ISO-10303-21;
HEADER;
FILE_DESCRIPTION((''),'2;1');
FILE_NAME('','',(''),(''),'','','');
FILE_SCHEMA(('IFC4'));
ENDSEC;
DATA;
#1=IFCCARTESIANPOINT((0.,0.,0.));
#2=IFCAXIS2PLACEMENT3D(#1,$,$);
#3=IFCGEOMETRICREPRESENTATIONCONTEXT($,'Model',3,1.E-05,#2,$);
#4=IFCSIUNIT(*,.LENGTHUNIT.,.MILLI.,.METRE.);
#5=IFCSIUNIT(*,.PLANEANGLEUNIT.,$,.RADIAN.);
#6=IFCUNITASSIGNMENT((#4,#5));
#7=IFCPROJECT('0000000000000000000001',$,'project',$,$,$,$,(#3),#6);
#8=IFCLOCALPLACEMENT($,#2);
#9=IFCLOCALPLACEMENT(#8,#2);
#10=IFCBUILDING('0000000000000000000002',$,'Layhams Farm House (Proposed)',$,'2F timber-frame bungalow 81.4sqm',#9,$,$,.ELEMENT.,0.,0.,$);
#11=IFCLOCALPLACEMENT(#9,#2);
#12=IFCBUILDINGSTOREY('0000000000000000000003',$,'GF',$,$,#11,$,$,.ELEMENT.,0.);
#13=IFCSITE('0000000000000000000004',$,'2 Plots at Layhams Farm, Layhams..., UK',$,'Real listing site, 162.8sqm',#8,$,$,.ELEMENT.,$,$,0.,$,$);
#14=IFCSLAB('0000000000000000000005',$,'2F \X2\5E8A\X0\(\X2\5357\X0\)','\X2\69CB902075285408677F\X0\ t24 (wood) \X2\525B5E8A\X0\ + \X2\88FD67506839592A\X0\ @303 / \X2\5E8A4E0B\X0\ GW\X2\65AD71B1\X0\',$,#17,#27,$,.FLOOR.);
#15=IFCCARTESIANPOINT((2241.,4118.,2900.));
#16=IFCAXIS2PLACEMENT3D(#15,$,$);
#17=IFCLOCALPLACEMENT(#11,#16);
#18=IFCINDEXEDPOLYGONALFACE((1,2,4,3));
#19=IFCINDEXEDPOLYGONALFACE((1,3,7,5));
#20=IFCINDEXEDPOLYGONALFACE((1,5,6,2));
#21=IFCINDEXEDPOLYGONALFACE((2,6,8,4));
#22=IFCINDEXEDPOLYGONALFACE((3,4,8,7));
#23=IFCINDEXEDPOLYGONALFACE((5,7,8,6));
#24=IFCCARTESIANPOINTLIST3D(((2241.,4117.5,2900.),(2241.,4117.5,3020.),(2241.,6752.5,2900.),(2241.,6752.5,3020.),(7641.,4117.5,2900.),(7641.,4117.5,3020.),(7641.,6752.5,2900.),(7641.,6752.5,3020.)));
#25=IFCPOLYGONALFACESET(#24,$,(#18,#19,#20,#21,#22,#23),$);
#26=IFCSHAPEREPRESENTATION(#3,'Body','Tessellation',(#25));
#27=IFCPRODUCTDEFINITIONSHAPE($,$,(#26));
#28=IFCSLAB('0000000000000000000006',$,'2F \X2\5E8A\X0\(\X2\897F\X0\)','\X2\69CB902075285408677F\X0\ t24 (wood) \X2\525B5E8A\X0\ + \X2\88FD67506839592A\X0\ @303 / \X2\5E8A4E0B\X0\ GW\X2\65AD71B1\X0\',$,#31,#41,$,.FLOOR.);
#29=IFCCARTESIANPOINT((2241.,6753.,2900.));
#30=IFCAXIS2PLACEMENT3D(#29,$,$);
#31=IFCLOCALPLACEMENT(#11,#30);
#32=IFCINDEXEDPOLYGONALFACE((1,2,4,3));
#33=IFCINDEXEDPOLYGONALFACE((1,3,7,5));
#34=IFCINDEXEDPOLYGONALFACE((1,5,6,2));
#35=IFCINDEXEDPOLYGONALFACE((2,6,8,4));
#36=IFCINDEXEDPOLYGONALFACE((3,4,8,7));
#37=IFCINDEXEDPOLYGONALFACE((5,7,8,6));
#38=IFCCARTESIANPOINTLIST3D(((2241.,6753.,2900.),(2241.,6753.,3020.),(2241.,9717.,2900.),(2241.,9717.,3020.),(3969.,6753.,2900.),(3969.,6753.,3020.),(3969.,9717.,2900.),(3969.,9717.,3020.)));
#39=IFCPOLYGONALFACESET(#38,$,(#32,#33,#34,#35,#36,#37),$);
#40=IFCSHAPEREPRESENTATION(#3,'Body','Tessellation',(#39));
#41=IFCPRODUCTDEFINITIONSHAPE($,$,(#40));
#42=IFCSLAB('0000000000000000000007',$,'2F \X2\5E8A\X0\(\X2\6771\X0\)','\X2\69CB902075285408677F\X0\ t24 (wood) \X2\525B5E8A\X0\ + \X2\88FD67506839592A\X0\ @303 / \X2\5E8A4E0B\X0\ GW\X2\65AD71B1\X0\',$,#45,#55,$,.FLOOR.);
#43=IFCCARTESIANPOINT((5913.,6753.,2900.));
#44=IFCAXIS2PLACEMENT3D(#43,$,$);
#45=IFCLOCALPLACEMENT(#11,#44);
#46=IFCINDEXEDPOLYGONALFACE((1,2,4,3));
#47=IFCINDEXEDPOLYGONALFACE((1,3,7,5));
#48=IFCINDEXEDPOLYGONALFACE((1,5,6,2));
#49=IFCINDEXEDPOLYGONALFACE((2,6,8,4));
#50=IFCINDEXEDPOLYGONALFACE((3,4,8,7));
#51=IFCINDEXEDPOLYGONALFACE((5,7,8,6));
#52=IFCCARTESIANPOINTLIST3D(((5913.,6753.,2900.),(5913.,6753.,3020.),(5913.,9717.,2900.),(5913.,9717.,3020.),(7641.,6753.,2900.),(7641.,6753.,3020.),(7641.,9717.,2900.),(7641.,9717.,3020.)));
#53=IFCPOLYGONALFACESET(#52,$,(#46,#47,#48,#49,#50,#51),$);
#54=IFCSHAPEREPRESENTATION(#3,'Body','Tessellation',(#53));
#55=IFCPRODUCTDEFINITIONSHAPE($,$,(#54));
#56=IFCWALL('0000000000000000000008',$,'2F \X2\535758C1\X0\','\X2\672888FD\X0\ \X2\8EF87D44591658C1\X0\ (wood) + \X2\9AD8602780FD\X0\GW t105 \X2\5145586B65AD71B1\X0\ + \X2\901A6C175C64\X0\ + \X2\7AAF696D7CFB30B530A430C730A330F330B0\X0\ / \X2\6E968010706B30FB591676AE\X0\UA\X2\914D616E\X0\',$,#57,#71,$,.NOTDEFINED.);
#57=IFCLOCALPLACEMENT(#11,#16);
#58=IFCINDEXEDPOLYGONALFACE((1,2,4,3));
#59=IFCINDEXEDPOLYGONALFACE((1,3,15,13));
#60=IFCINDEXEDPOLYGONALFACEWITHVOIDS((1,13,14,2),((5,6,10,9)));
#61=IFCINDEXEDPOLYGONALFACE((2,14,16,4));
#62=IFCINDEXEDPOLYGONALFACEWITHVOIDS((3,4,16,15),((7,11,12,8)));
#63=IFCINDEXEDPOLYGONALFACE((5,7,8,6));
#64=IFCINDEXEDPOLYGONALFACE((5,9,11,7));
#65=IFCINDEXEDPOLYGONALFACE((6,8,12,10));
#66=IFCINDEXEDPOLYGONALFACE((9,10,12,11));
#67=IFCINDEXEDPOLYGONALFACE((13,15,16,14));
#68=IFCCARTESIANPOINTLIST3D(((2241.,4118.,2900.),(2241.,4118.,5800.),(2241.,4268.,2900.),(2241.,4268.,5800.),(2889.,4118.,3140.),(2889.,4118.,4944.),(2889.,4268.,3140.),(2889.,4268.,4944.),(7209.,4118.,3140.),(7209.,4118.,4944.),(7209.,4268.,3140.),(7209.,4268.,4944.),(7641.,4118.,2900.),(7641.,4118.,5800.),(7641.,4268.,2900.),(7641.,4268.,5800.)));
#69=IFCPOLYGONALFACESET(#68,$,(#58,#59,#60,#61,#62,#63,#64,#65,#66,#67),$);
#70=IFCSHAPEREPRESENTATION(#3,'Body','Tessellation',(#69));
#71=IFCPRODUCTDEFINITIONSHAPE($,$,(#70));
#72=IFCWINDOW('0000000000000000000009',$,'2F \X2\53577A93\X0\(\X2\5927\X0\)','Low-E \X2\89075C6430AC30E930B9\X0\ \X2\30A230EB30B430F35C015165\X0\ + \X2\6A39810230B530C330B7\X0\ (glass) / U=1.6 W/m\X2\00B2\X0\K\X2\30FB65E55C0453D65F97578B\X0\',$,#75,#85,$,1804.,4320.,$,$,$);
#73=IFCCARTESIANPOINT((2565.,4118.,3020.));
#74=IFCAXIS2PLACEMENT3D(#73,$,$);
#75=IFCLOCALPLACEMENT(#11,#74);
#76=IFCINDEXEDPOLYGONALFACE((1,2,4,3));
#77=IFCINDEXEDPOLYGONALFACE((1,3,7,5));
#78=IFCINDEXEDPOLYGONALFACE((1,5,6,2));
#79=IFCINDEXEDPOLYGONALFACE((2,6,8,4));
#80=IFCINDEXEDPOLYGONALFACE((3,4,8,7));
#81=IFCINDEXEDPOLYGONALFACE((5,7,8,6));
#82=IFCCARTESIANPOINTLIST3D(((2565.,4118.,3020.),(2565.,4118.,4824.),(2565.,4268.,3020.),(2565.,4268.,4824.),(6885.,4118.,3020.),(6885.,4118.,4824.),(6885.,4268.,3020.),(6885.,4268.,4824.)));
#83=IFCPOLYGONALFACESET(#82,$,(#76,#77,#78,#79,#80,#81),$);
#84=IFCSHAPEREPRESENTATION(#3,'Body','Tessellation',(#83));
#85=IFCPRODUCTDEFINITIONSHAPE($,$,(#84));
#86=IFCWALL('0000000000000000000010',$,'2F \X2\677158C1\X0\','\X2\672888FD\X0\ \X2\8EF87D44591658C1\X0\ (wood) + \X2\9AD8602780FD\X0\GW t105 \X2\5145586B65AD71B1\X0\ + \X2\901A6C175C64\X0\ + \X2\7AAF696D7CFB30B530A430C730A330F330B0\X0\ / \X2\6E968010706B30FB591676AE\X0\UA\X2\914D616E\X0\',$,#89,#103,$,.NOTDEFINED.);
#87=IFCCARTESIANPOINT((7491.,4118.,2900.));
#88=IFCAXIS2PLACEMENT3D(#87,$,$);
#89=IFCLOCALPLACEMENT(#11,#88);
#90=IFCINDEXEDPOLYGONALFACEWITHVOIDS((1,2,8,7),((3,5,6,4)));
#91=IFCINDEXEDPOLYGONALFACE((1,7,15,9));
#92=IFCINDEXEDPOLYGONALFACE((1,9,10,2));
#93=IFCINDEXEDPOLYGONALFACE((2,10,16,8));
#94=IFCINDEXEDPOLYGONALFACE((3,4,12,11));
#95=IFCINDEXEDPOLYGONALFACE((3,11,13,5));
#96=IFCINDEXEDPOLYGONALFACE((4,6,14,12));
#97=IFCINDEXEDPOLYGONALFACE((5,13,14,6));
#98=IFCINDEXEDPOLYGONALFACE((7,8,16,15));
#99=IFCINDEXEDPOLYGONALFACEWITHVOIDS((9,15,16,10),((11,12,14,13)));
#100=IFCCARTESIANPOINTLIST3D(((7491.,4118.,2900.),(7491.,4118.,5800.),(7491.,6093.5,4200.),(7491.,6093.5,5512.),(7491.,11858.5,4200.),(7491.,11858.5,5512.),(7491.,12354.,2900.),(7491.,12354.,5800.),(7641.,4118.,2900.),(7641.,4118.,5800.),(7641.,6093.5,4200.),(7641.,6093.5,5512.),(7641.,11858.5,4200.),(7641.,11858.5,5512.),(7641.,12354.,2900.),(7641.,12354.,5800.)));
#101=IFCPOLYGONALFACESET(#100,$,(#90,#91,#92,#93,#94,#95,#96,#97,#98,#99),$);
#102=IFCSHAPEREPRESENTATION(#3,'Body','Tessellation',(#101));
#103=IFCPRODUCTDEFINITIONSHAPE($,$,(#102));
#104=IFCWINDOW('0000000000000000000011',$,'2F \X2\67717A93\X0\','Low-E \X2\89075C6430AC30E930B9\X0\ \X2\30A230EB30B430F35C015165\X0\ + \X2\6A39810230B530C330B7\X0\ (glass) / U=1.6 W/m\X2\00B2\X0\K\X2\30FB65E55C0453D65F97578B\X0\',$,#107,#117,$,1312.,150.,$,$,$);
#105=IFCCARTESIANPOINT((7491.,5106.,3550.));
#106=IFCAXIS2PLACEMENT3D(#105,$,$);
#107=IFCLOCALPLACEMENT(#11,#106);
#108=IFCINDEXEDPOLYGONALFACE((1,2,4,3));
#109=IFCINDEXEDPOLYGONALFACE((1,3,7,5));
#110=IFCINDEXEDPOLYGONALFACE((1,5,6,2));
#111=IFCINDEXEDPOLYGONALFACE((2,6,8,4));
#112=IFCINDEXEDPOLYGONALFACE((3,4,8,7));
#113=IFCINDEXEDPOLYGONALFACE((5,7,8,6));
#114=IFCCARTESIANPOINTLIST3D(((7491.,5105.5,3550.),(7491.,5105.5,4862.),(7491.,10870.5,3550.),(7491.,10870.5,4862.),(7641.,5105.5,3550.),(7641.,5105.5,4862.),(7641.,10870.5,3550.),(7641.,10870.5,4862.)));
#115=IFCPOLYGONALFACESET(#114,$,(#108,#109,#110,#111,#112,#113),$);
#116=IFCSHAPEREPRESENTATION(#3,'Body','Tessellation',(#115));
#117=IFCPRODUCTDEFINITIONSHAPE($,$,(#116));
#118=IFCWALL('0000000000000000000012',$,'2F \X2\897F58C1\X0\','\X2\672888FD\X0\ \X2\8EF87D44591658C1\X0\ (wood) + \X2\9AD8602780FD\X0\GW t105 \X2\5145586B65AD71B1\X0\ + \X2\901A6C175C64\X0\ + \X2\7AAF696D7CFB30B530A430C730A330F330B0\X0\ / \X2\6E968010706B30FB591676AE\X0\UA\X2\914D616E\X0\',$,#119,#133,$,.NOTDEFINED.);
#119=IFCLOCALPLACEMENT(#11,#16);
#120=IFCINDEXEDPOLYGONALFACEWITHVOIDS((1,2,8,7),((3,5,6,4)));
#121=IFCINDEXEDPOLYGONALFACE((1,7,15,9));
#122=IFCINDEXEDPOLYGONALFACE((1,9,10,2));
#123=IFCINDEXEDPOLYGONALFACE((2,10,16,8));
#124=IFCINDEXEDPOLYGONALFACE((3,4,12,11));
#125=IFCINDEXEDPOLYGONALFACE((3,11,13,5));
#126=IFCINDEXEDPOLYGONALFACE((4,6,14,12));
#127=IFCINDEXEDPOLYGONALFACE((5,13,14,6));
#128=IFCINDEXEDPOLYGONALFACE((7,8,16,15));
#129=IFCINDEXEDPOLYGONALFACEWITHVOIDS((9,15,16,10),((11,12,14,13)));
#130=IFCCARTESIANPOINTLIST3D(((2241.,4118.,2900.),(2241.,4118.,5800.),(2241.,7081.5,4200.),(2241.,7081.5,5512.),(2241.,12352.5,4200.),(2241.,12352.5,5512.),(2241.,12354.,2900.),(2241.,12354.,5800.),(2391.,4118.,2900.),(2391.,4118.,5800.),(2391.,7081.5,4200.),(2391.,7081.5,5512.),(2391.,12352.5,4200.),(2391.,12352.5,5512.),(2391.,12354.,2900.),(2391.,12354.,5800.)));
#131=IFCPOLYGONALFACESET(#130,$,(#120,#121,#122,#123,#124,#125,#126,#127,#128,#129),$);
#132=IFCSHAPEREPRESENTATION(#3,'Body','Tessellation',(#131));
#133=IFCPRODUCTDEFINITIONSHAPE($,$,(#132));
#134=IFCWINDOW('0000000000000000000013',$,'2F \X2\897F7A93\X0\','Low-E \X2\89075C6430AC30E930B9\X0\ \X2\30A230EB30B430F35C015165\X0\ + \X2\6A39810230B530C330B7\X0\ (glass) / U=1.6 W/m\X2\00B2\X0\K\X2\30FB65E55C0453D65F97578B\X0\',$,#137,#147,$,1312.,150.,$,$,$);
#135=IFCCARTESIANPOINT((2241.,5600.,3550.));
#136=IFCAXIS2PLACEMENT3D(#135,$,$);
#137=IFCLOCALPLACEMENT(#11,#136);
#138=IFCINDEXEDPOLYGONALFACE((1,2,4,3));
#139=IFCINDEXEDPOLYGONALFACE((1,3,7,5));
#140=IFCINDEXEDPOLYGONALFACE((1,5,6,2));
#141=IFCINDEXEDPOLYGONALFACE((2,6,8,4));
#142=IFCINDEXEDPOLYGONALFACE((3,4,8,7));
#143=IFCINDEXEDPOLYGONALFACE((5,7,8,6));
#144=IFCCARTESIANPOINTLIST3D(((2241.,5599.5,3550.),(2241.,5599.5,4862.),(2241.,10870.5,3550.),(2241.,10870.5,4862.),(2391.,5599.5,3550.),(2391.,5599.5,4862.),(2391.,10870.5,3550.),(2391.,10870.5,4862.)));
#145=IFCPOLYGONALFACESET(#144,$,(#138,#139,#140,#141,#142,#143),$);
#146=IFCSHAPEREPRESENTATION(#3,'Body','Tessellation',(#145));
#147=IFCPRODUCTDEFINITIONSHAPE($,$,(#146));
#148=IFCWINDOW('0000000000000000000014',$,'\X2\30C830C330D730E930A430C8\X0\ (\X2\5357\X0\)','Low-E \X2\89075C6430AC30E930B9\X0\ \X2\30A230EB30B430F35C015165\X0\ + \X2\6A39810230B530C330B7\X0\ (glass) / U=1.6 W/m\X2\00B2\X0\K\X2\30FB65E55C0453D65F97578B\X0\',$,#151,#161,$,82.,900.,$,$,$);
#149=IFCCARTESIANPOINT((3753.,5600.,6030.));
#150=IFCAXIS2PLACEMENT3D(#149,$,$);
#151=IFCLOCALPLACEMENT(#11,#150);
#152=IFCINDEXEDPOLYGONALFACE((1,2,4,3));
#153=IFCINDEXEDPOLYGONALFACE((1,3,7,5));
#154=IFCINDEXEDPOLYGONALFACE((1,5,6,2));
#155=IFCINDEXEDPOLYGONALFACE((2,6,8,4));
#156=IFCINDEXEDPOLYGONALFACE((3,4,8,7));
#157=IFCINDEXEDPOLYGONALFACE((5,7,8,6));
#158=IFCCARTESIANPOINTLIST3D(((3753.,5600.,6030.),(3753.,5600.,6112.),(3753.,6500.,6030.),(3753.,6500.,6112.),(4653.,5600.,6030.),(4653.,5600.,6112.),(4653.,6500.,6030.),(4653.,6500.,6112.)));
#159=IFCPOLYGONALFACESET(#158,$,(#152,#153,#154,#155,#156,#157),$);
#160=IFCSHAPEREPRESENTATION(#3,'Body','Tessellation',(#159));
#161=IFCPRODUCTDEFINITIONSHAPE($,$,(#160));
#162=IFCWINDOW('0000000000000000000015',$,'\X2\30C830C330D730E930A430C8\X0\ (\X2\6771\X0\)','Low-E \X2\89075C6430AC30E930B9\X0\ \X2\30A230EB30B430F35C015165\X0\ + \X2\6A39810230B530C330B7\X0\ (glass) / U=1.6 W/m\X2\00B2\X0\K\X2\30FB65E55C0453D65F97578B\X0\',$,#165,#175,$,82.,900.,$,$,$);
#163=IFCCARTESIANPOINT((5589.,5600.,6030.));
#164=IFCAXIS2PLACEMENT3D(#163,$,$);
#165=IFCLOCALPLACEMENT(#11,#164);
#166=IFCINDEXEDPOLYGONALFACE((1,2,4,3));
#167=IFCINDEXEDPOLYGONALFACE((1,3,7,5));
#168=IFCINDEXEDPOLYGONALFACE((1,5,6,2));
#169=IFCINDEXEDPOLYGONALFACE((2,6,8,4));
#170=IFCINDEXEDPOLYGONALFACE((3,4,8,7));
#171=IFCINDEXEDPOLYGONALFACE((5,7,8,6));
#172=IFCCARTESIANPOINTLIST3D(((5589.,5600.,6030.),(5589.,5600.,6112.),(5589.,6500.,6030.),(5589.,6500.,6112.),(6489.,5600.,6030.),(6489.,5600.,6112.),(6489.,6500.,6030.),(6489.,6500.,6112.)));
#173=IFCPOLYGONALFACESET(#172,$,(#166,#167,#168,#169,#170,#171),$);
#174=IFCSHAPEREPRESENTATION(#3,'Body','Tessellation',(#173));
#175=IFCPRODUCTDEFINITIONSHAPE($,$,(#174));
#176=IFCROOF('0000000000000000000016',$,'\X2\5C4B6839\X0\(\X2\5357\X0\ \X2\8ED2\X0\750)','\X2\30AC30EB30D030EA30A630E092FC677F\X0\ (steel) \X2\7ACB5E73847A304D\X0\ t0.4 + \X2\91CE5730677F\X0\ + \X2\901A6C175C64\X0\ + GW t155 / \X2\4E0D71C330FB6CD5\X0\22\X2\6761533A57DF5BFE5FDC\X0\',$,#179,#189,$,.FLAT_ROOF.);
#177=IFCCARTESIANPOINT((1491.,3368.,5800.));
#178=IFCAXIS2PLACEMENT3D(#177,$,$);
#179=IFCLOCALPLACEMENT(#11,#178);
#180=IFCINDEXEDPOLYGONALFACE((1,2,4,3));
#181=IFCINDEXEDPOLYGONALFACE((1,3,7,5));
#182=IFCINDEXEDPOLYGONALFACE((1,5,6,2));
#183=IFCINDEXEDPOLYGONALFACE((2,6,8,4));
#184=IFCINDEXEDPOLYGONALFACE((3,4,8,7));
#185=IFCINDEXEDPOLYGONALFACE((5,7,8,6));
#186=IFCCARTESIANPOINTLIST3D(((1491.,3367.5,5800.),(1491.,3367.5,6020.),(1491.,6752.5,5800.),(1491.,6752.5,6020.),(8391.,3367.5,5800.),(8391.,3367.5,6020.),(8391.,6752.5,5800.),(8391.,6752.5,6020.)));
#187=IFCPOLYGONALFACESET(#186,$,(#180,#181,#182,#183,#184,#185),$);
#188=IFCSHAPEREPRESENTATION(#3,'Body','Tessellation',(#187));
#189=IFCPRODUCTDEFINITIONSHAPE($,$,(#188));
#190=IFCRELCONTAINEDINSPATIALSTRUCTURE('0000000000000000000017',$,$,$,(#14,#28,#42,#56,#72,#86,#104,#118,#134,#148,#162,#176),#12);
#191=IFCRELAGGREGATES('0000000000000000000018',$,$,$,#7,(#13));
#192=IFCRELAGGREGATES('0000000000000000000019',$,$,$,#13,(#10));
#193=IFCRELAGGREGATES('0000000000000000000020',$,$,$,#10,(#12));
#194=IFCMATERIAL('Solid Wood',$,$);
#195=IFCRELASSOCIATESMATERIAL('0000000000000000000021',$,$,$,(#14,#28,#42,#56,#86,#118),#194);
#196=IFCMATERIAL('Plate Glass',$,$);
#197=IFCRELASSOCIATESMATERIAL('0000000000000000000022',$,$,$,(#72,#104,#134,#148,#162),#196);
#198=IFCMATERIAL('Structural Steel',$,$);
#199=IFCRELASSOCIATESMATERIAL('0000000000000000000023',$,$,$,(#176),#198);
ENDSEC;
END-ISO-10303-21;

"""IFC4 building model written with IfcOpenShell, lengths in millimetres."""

from ifc_helpers import new_model, si_unit, frame, frame_2d, origin, place, context, project, spatial, rectangle, extrude, material, element, fill, save


model = new_model("IFC4")

# Units and contexts
model_context = context("Model", 3, precision=1e-05, world=origin())
ifc_project = project(units=[si_unit("LENGTHUNIT", "METRE", prefix="MILLI"), si_unit("PLANEANGLEUNIT", "RADIAN")], contexts=[model_context])

# Site, building, storey
site_placement = place(None, origin())
site = spatial("IfcSite", under=ifc_project, at=site_placement, Name="2 Plots at Layhams Farm, Layhams..., UK", ObjectType="Real listing site, 162.8sqm", CompositionType="ELEMENT", RefElevation=0.0)
building_placement = place(site_placement, origin())
building = spatial("IfcBuilding", under=site, at=building_placement, Name="Layhams Farm House (Proposed)", ObjectType="2F timber-frame bungalow 81.4sqm", CompositionType="ELEMENT", ElevationOfRefHeight=0.0, ElevationOfTerrain=0.0)
storey_placement = place(building_placement, origin())
storey = spatial("IfcBuildingStorey", under=building, at=storey_placement, Name="GF", CompositionType="ELEMENT", Elevation=0.0)

# Slabs
ifc_material_1 = material(Name="Solid Wood")
slab_1_placement = place(storey_placement, frame((2241.0, 4118.0, 2900.0)))
element("IfcSlab", 1, at=slab_1_placement, inside=storey, material=ifc_material_1, Name="2F 床(南)", Description="構造用合板 t24 (wood) 剛床 + 製材根太 @303 / 床下 GW断熱", PredefinedType="FLOOR", context=model_context, shape_type="SweptSolid", body=[
    extrude(rectangle(XDim=5400.0, YDim=2635.0, at=frame_2d((2700.0, 1317.0))), frame((2241.0, 4118.0, 2900.0)), (0.0, 0.0, 1.0), 120.0),
])
slab_2_placement = place(storey_placement, frame((2241.0, 6753.0, 2900.0)))
element("IfcSlab", 2, at=slab_2_placement, inside=storey, material=ifc_material_1, Name="2F 床(西)", Description="構造用合板 t24 (wood) 剛床 + 製材根太 @303 / 床下 GW断熱", PredefinedType="FLOOR", context=model_context, shape_type="SweptSolid", body=[
    extrude(rectangle(XDim=1728.0, YDim=2964.0, at=frame_2d((864.0, 1482.0))), frame((2241.0, 6753.0, 2900.0)), (0.0, 0.0, 1.0), 120.0),
])
slab_3_placement = place(storey_placement, frame((5913.0, 6753.0, 2900.0)))
element("IfcSlab", 3, at=slab_3_placement, inside=storey, material=ifc_material_1, Name="2F 床(東)", Description="構造用合板 t24 (wood) 剛床 + 製材根太 @303 / 床下 GW断熱", PredefinedType="FLOOR", context=model_context, shape_type="SweptSolid", body=[
    extrude(rectangle(XDim=1728.0, YDim=2964.0, at=frame_2d((864.0, 1482.0))), frame((5913.0, 6753.0, 2900.0)), (0.0, 0.0, 1.0), 120.0),
])

# Walls, openings, windows
wall_1_placement = place(storey_placement, frame((2241.0, 4118.0, 2900.0)))
wall_1 = element("IfcWall", 4, at=wall_1_placement, inside=storey, material=ifc_material_1, Name="2F 南壁", Description="木製 軸組外壁 (wood) + 高性能GW t105 充填断熱 + 通気層 + 窯業系サイディング / 準耐火・外皮UA配慮", PredefinedType="NOTDEFINED", context=model_context, shape_type="SweptSolid", body=[
    extrude(rectangle(XDim=5400.0, YDim=150.0, at=frame_2d((2700.0, 75.0))), frame((2241.0, 4118.0, 2900.0)), (0.0, 0.0, 1.0), 2900.0),
])
opening_1_placement = place(storey_placement, frame((2565.0, 4118.0, 3020.0)))
opening_1 = element("IfcOpeningElement", 5, at=opening_1_placement, cuts=wall_1, PredefinedType="NOTDEFINED", context=model_context, shape_type="SweptSolid", body=[
    extrude(rectangle(XDim=4320.0, YDim=150.0, at=frame_2d((2160.0, 75.0))), frame((2565.0, 4118.0, 3020.0)), (0.0, 0.0, 1.0), 1804.0),
])
ifc_material_2 = material(Name="Plate Glass")
window_1_placement = place(storey_placement, frame((2565.0, 4118.0, 3020.0)))
window_1 = element("IfcWindow", 6, at=window_1_placement, inside=storey, material=ifc_material_2, Name="2F 南窓(大)", Description="Low-E 複層ガラス アルゴン封入 + 樹脂サッシ (glass) / U=1.6 W/m²K・日射取得型", OverallHeight=1804.0, OverallWidth=4320.0, context=model_context, shape_type="SweptSolid", body=[
    extrude(rectangle(XDim=4320.0, YDim=150.0, at=frame_2d((2160.0, 75.0))), frame((2565.0, 4118.0, 3020.0)), (0.0, 0.0, 1.0), 1804.0),
])
fill(opening_1, window_1)
wall_2_placement = place(storey_placement, frame((7491.0, 4118.0, 2900.0)))
wall_2 = element("IfcWall", 7, at=wall_2_placement, inside=storey, material=ifc_material_1, Name="2F 東壁", Description="木製 軸組外壁 (wood) + 高性能GW t105 充填断熱 + 通気層 + 窯業系サイディング / 準耐火・外皮UA配慮", PredefinedType="NOTDEFINED", context=model_context, shape_type="SweptSolid", body=[
    extrude(rectangle(XDim=150.0, YDim=8236.0, at=frame_2d((75.0, 4118.0))), frame((7491.0, 4118.0, 2900.0)), (0.0, 0.0, 1.0), 2900.0),
])
opening_2_placement = place(storey_placement, frame((7491.0, 5106.0, 3550.0)))
opening_2 = element("IfcOpeningElement", 8, at=opening_2_placement, cuts=wall_2, PredefinedType="NOTDEFINED", context=model_context, shape_type="SweptSolid", body=[
    extrude(rectangle(XDim=150.0, YDim=5765.0, at=frame_2d((75.0, 2882.0))), frame((7491.0, 5106.0, 3550.0)), (0.0, 0.0, 1.0), 1312.0),
])
window_2_placement = place(storey_placement, frame((7491.0, 5106.0, 3550.0)))
window_2 = element("IfcWindow", 9, at=window_2_placement, inside=storey, material=ifc_material_2, Name="2F 東窓", Description="Low-E 複層ガラス アルゴン封入 + 樹脂サッシ (glass) / U=1.6 W/m²K・日射取得型", OverallHeight=1312.0, OverallWidth=150.0, context=model_context, shape_type="SweptSolid", body=[
    extrude(rectangle(XDim=150.0, YDim=5765.0, at=frame_2d((75.0, 2882.0))), frame((7491.0, 5106.0, 3550.0)), (0.0, 0.0, 1.0), 1312.0),
])
fill(opening_2, window_2)
wall_3_placement = place(storey_placement, frame((2241.0, 4118.0, 2900.0)))
wall_3 = element("IfcWall", 10, at=wall_3_placement, inside=storey, material=ifc_material_1, Name="2F 西壁", Description="木製 軸組外壁 (wood) + 高性能GW t105 充填断熱 + 通気層 + 窯業系サイディング / 準耐火・外皮UA配慮", PredefinedType="NOTDEFINED", context=model_context, shape_type="SweptSolid", body=[
    extrude(rectangle(XDim=150.0, YDim=8236.0, at=frame_2d((75.0, 4118.0))), frame((2241.0, 4118.0, 2900.0)), (0.0, 0.0, 1.0), 2900.0),
])
opening_3_placement = place(storey_placement, frame((2241.0, 5600.0, 3550.0)))
opening_3 = element("IfcOpeningElement", 11, at=opening_3_placement, cuts=wall_3, PredefinedType="NOTDEFINED", context=model_context, shape_type="SweptSolid", body=[
    extrude(rectangle(XDim=150.0, YDim=5271.0, at=frame_2d((75.0, 2635.0))), frame((2241.0, 5600.0, 3550.0)), (0.0, 0.0, 1.0), 1312.0),
])
window_3_placement = place(storey_placement, frame((2241.0, 5600.0, 3550.0)))
window_3 = element("IfcWindow", 12, at=window_3_placement, inside=storey, material=ifc_material_2, Name="2F 西窓", Description="Low-E 複層ガラス アルゴン封入 + 樹脂サッシ (glass) / U=1.6 W/m²K・日射取得型", OverallHeight=1312.0, OverallWidth=150.0, context=model_context, shape_type="SweptSolid", body=[
    extrude(rectangle(XDim=150.0, YDim=5271.0, at=frame_2d((75.0, 2635.0))), frame((2241.0, 5600.0, 3550.0)), (0.0, 0.0, 1.0), 1312.0),
])
fill(opening_3, window_3)

# Windows
window_4_placement = place(storey_placement, frame((3753.0, 5600.0, 6030.0)))
element("IfcWindow", 13, at=window_4_placement, inside=storey, material=ifc_material_2, Name="トップライト (南)", Description="Low-E 複層ガラス アルゴン封入 + 樹脂サッシ (glass) / U=1.6 W/m²K・日射取得型", OverallHeight=82.0, OverallWidth=900.0, context=model_context, shape_type="SweptSolid", body=[
    extrude(rectangle(XDim=900.0, YDim=900.0, at=frame_2d((450.0, 450.0))), frame((3753.0, 5600.0, 6030.0)), (0.0, 0.0, 1.0), 82.0),
])
window_5_placement = place(storey_placement, frame((5589.0, 5600.0, 6030.0)))
element("IfcWindow", 14, at=window_5_placement, inside=storey, material=ifc_material_2, Name="トップライト (東)", Description="Low-E 複層ガラス アルゴン封入 + 樹脂サッシ (glass) / U=1.6 W/m²K・日射取得型", OverallHeight=82.0, OverallWidth=900.0, context=model_context, shape_type="SweptSolid", body=[
    extrude(rectangle(XDim=900.0, YDim=900.0, at=frame_2d((450.0, 450.0))), frame((5589.0, 5600.0, 6030.0)), (0.0, 0.0, 1.0), 82.0),
])

# Roof
ifc_material_3 = material(Name="Structural Steel")
roof_1_placement = place(storey_placement, frame((1491.0, 3368.0, 5800.0)))
element("IfcRoof", 15, at=roof_1_placement, inside=storey, material=ifc_material_3, Name="屋根(南 軒750)", Description="ガルバリウム鋼板 (steel) 立平葺き t0.4 + 野地板 + 通気層 + GW t155 / 不燃・法22条区域対応", PredefinedType="FLAT_ROOF", context=model_context, shape_type="SweptSolid", body=[
    extrude(rectangle(XDim=6900.0, YDim=3385.0, at=frame_2d((3450.0, 1692.0))), frame((1491.0, 3368.0, 5800.0)), (0.0, 0.0, 1.0), 220.0),
])

save(model, "model.ifc")
